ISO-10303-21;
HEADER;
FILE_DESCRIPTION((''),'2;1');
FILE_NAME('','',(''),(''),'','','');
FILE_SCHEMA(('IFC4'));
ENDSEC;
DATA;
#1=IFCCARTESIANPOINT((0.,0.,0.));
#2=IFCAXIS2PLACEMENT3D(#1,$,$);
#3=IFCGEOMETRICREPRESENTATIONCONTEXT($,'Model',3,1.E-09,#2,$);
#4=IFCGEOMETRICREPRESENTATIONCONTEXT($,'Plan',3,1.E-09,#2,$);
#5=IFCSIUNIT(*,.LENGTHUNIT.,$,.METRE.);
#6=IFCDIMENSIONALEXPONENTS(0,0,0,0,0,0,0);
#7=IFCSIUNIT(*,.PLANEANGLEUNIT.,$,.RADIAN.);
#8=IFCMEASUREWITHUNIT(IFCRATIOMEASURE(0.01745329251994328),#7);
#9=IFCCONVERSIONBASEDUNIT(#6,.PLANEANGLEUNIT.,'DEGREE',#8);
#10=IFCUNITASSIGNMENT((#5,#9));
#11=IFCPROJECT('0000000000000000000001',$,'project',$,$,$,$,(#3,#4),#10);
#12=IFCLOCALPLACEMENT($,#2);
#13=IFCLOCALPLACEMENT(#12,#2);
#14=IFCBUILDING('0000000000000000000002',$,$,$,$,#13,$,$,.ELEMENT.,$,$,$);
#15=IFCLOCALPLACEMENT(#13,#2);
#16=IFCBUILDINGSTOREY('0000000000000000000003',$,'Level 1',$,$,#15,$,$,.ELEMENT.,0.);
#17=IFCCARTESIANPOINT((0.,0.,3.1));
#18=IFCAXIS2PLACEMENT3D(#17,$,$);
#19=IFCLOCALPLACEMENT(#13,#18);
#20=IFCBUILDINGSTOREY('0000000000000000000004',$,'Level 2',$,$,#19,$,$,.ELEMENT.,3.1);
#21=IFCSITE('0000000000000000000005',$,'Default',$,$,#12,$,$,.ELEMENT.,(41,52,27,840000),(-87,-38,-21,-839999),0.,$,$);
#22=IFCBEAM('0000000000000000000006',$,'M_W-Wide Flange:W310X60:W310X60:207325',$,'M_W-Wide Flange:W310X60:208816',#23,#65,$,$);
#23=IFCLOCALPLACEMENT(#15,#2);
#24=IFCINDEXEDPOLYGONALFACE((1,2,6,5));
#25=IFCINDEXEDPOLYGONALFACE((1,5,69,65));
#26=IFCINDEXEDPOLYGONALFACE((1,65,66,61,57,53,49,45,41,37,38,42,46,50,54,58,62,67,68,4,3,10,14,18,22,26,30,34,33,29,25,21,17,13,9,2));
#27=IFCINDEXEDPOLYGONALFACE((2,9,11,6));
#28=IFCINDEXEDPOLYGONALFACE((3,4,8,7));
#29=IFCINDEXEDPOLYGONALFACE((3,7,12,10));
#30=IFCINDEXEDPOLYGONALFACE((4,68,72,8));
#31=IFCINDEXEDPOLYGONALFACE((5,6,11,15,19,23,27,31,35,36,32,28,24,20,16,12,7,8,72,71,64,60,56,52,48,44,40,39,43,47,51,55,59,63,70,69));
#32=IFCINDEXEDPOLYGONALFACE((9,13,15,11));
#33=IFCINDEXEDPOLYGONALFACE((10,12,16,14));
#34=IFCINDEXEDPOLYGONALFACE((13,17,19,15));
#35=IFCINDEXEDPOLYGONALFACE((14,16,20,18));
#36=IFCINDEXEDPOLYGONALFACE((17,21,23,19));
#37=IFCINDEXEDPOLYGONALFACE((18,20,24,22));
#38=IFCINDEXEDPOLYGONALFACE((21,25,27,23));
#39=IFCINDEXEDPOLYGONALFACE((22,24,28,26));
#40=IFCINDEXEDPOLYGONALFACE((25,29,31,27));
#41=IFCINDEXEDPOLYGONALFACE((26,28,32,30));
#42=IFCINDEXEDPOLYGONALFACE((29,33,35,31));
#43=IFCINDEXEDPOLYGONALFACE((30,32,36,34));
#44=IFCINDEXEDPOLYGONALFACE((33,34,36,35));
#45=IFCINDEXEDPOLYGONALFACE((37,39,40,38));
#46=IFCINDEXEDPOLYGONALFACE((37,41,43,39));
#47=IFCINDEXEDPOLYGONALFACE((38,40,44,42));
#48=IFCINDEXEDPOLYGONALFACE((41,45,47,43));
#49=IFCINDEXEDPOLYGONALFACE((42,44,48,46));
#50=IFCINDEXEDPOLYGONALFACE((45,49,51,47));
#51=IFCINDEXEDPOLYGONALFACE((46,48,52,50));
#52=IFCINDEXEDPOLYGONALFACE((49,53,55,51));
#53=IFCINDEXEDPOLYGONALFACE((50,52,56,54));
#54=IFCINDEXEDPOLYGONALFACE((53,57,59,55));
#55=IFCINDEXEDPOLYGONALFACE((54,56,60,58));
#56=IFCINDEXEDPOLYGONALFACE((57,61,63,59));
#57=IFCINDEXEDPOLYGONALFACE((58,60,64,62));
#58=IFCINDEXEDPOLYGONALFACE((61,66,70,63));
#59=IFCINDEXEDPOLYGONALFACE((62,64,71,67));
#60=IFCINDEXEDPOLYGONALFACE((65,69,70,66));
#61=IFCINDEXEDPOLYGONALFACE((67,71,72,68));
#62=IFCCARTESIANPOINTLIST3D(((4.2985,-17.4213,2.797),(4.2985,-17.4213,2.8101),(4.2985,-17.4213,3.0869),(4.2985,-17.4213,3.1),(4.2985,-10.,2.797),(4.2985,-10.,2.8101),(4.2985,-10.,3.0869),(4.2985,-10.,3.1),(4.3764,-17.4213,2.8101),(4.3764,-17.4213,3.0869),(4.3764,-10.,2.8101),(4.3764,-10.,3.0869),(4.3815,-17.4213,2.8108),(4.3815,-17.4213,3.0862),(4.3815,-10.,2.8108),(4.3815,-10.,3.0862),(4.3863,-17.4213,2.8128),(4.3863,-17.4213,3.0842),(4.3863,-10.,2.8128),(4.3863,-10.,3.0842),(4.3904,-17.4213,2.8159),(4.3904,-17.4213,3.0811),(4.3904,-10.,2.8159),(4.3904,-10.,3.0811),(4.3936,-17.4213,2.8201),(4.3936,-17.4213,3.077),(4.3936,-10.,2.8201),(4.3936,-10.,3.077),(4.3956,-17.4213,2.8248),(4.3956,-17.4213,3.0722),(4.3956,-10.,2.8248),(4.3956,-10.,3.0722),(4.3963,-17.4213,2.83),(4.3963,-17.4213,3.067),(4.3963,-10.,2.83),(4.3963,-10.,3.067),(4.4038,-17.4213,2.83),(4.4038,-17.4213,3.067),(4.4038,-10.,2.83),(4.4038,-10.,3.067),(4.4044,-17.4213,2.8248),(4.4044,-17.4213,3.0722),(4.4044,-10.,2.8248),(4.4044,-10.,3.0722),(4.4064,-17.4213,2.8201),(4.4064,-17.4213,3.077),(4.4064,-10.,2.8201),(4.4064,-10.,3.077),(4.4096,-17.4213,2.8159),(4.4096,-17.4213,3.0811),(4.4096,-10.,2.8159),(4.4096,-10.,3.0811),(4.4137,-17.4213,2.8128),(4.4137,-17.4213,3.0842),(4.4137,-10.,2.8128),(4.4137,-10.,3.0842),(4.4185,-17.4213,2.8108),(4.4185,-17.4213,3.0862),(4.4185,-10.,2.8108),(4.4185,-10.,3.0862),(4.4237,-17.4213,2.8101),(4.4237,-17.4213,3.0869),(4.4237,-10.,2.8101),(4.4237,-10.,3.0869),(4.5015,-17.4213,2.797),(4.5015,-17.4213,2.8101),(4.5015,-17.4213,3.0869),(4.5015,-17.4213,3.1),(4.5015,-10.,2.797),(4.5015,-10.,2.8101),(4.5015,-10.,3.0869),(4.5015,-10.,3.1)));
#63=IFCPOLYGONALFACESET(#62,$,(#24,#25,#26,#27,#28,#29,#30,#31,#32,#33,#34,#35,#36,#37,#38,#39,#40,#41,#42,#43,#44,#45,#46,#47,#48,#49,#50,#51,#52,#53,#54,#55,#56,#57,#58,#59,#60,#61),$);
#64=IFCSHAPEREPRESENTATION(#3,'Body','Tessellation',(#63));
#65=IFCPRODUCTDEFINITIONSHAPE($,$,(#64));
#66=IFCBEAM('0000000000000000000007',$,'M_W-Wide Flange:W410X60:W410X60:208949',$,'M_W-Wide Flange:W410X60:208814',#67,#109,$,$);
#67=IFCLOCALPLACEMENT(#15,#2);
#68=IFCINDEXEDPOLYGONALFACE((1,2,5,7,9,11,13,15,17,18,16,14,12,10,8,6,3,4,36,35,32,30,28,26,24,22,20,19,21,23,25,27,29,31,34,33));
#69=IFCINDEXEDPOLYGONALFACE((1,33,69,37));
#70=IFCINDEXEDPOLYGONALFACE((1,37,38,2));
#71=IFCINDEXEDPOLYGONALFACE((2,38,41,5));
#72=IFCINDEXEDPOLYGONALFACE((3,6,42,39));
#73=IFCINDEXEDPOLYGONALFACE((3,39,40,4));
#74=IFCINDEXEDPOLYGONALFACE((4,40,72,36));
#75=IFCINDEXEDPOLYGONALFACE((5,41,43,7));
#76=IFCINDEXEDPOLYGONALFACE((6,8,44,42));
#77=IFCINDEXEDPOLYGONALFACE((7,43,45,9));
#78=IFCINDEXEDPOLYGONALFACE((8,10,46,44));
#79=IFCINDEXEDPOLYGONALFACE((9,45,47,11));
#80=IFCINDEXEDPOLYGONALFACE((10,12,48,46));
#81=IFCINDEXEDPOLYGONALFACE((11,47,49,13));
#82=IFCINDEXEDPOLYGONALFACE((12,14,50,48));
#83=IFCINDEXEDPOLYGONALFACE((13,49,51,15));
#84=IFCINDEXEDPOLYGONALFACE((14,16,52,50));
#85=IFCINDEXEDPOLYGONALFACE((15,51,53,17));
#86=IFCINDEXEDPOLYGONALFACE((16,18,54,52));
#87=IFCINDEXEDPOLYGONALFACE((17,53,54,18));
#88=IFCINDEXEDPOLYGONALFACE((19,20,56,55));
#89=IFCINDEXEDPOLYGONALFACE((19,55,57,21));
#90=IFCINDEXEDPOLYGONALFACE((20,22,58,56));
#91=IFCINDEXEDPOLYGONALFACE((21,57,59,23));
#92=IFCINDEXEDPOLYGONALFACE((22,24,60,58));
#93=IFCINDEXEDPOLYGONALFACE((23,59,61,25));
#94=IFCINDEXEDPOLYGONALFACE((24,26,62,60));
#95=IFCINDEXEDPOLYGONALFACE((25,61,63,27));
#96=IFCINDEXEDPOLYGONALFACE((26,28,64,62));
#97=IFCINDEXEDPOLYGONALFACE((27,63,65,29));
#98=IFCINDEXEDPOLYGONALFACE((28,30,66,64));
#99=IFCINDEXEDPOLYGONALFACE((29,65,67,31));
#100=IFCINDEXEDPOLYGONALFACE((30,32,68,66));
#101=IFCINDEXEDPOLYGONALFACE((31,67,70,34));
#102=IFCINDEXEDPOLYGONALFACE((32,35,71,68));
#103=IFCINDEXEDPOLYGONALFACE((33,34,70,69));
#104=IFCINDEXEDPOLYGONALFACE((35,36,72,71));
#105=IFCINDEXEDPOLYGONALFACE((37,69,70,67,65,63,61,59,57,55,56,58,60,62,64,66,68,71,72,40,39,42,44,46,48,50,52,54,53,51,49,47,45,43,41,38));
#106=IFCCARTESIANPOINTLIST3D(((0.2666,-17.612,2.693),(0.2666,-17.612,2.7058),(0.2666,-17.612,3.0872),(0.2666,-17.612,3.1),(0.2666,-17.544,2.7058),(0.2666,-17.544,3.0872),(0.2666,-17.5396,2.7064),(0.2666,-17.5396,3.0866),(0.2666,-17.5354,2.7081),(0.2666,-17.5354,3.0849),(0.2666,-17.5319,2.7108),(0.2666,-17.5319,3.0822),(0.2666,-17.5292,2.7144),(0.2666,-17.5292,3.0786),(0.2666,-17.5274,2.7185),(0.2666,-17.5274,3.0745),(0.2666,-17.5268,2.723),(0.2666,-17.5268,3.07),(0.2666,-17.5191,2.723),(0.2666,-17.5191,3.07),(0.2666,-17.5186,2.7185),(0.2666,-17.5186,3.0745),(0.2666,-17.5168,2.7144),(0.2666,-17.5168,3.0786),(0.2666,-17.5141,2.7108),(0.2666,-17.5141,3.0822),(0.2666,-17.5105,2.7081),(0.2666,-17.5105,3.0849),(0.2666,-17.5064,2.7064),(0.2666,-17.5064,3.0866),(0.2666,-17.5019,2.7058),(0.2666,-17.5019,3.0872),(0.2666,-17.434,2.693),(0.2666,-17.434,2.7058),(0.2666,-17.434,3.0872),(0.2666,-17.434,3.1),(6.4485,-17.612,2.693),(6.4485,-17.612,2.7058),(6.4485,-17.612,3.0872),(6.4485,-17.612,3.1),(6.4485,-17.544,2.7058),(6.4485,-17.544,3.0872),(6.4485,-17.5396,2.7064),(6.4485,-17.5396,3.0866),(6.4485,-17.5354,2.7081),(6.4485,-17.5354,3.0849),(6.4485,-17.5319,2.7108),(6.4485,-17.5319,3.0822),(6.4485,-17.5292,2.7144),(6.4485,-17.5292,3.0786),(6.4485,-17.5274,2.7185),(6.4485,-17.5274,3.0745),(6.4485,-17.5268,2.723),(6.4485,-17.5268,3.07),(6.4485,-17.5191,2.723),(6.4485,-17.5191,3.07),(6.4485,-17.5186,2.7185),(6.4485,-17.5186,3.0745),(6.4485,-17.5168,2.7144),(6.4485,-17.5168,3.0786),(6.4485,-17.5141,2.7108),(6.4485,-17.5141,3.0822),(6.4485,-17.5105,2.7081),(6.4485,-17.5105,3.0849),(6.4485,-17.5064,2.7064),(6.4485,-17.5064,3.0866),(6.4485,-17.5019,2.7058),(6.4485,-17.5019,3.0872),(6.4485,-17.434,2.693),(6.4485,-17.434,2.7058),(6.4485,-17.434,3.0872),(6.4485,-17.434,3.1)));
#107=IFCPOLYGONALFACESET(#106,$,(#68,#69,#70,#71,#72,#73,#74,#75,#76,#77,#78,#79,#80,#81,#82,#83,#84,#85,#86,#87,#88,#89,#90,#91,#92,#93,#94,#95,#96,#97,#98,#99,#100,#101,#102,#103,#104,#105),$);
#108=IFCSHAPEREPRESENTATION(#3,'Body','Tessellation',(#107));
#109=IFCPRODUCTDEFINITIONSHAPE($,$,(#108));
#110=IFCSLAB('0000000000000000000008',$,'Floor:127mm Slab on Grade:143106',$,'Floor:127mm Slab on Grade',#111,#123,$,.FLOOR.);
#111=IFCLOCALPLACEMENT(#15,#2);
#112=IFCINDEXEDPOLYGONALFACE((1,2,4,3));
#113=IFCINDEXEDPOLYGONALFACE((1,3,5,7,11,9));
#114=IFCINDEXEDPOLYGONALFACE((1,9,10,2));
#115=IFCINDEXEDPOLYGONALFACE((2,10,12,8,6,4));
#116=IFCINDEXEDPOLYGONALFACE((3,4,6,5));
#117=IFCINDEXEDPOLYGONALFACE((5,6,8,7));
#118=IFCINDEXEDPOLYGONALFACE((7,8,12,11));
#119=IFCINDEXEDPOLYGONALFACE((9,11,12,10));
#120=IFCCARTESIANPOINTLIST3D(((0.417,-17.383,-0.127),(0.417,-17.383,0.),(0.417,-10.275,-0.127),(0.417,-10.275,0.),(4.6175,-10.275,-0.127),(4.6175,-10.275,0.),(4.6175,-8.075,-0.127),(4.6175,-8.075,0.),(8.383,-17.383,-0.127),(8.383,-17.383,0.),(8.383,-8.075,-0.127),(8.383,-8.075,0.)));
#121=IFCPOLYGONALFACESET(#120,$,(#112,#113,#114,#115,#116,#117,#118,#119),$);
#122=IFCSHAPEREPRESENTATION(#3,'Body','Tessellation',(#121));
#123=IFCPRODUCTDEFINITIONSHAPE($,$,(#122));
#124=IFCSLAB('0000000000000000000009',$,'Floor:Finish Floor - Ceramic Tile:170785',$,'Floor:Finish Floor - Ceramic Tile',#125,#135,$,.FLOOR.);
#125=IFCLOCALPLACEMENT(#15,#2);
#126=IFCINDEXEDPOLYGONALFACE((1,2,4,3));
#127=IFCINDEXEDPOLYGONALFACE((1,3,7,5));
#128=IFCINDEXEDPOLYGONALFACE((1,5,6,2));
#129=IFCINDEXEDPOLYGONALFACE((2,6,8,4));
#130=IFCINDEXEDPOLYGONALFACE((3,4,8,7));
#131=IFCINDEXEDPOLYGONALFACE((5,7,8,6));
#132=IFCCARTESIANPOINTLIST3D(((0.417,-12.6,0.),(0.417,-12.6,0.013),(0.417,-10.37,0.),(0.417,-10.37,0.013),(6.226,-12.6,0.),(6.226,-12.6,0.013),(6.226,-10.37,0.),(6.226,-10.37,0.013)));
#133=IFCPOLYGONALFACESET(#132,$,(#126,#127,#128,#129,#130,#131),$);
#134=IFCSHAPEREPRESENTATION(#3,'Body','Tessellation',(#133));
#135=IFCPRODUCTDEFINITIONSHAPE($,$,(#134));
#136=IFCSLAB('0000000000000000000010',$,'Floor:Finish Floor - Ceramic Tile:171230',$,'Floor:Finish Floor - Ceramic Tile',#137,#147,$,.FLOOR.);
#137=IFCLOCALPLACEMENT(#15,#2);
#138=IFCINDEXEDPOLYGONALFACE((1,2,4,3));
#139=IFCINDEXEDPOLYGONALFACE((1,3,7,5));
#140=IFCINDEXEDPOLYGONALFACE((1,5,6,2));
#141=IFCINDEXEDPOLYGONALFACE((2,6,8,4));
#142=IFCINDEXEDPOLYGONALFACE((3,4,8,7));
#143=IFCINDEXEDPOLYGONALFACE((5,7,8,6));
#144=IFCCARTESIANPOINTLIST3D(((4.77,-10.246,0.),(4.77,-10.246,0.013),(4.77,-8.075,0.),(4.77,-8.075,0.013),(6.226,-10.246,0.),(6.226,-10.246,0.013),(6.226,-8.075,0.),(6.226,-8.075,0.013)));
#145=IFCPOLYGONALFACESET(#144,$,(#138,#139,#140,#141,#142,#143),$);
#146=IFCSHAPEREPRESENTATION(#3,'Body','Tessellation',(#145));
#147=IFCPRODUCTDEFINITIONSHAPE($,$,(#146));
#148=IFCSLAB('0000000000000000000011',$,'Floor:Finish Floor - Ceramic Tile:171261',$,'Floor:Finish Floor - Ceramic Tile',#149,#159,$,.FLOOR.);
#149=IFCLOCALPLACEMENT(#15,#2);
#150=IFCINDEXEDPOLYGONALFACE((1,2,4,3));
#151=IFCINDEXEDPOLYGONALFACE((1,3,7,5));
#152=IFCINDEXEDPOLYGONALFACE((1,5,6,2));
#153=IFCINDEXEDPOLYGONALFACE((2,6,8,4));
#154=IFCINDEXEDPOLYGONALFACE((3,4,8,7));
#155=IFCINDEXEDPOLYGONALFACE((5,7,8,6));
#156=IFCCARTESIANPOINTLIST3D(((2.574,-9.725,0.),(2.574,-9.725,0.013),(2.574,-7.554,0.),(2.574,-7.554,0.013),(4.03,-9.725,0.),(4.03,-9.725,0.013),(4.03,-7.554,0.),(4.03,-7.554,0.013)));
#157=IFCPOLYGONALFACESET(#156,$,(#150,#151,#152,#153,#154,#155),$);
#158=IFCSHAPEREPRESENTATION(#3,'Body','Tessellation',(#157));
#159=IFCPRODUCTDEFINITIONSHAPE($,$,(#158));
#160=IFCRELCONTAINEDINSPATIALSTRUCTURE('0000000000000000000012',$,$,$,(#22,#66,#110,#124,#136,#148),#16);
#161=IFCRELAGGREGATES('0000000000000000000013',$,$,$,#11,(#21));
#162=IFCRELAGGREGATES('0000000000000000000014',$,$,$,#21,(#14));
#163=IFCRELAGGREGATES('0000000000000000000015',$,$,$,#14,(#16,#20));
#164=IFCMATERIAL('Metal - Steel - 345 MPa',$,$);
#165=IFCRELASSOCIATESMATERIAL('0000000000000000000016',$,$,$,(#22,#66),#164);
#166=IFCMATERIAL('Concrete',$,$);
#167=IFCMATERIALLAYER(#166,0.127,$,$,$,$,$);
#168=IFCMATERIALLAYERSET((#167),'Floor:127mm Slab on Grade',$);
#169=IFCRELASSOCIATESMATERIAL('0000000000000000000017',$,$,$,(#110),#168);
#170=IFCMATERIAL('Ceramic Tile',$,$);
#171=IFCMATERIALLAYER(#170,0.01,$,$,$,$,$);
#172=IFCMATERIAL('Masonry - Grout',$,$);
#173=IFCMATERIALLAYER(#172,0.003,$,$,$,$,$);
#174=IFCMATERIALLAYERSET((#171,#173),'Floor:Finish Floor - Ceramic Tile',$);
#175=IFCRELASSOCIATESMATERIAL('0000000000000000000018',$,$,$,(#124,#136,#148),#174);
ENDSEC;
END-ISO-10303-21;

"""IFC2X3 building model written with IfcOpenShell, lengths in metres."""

from ifc_helpers import new_model, entity, si_unit, converted_unit, frame, frame_2d, origin, place, context, project, spatial, polyline, circle_curve, parameter, trimmed, segment, composite_curve, rectangle, outline, extrude, material, layer, layer_set, layer_usage, element, save


model = new_model("IFC2X3")

# Units and contexts
model_context = context("Model", 3, precision=1e-09, world=origin())
plan_context = context("Plan", 3, precision=1e-09, world=origin())
ifc_project = project(units=[si_unit("LENGTHUNIT", "METRE"), converted_unit("PLANEANGLEUNIT", "DEGREE", entity("IfcRatioMeasure", 0.01745329251994328), si_unit("PLANEANGLEUNIT", "RADIAN"), dimensions=[0, 0, 0, 0, 0, 0, 0])], contexts=[model_context, plan_context])

# Site, building, storey
site_placement = place(None, origin())
site = spatial("IfcSite", under=ifc_project, at=site_placement, Name="Default", CompositionType="ELEMENT", RefLatitude=(41, 52, 27, 840000), RefLongitude=(-87, -38, -21, -839999), RefElevation=0.0)
building_placement = place(site_placement, origin())
building = spatial("IfcBuilding", under=site, at=building_placement, CompositionType="ELEMENT")
storey_1_placement = place(building_placement, origin())
storey_1 = spatial("IfcBuildingStorey", under=building, at=storey_1_placement, Name="Level 1", CompositionType="ELEMENT", Elevation=0.0)

# Beams
ifc_material_1 = material(Name="Metal - Steel - 345 MPa")
beam_1_placement = place(storey_1_placement, frame((4.4, -10.0, 3.1), z_axis=(0.0, 0.0, 1.0), x_axis=(-1.0, 0.0, 0.0)))
element("IfcBeam", 1, at=beam_1_placement, inside=storey_1, material=ifc_material_1, Name="M_W-Wide Flange:W310X60:W310X60:207325", ObjectType="M_W-Wide Flange:W310X60:208816", context=model_context, shape_type="SweptSolid", body=[
    extrude(outline(composite_curve([segment(polyline([(0.1384, -0.1015), (0.1515, -0.1015)]), True, "CONTINUOUS"), segment(polyline([(0.1515, -0.1015), (0.1515, 0.1015)]), True, "CONTINUOUS"), segment(polyline([(0.1515, 0.1015), (0.1384, 0.1015)]), True, "CONTINUOUS"), segment(polyline([(0.1384, 0.1015), (0.1384, 0.0236)]), True, "CONTINUOUS"), segment(trimmed(circle_curve(frame_2d((0.1185, 0.0236), x_axis=(0.0, 1.0)), 0.0199), [parameter(180.0)], [parameter(270.0)], True, "PARAMETER"), False, "CONTINUOUS"), segment(polyline([(0.1185, 0.0037), (-0.1185, 0.0037)]), True, "CONTINUOUS"), segment(trimmed(circle_curve(frame_2d((-0.1185, 0.0236), x_axis=(0.0, 1.0)), 0.0199), [parameter(90.0)], [parameter(180.0)], True, "PARAMETER"), False, "CONTINUOUS"), segment(polyline([(-0.1384, 0.0236), (-0.1384, 0.1015)]), True, "CONTINUOUS"), segment(polyline([(-0.1384, 0.1015), (-0.1515, 0.1015)]), True, "CONTINUOUS"), segment(polyline([(-0.1515, 0.1015), (-0.1515, -0.1015)]), True, "CONTINUOUS"), segment(polyline([(-0.1515, -0.1015), (-0.1384, -0.1015)]), True, "CONTINUOUS"), segment(polyline([(-0.1384, -0.1015), (-0.1384, -0.0237)]), True, "CONTINUOUS"), segment(trimmed(circle_curve(frame_2d((-0.1185, -0.0237), x_axis=(0.0, 1.0)), 0.0199), [parameter(360.0)], [parameter(90.0)], True, "PARAMETER"), False, "CONTINUOUS"), segment(polyline([(-0.1185, -0.0038), (0.1185, -0.0038)]), True, "CONTINUOUS"), segment(trimmed(circle_curve(frame_2d((0.1185, -0.0237), x_axis=(0.0, 1.0)), 0.0199), [parameter(270.0)], [parameter(0.0)], True, "PARAMETER"), False, "CONTINUOUS"), segment(polyline([(0.1384, -0.0237), (0.1384, -0.1015)]), True, "CONTINUOUS")], self_intersect=False)), frame((0.0, 7.4213, -0.1515), z_axis=(0.0, -1.0, 0.0), x_axis=(0.0, 0.0, -1.0)), (0.0, 0.0, 1.0), 7.4213),
])
beam_2_placement = place(storey_1_placement, frame((0.2085, -17.523, 3.1), z_axis=(0.0, 0.0, 1.0), x_axis=(0.0, -1.0, 0.0)))
element("IfcBeam", 2, at=beam_2_placement, inside=storey_1, material=ifc_material_1, Name="M_W-Wide Flange:W410X60:W410X60:208949", ObjectType="M_W-Wide Flange:W410X60:208814", context=model_context, shape_type="SweptSolid", body=[
    extrude(outline(composite_curve([segment(polyline([(-0.089, -0.1907), (-0.089, -0.2035)]), True, "CONTINUOUS"), segment(polyline([(-0.089, -0.2035), (0.089, -0.2035)]), True, "CONTINUOUS"), segment(polyline([(0.089, -0.2035), (0.089, -0.1907)]), True, "CONTINUOUS"), segment(polyline([(0.089, -0.1907), (0.021, -0.1907)]), True, "CONTINUOUS"), segment(trimmed(circle_curve(frame_2d((0.021, -0.1735), x_axis=(0.0, -1.0)), 0.0172), [parameter(270.0)], [parameter(360.0)], True, "PARAMETER"), False, "CONTINUOUS"), segment(polyline([(0.0038, -0.1735), (0.0038, 0.1735)]), True, "CONTINUOUS"), segment(trimmed(circle_curve(frame_2d((0.021, 0.1735), x_axis=(-1.0, 0.0)), 0.0172), [parameter(270.0)], [parameter(360.0)], True, "PARAMETER"), False, "CONTINUOUS"), segment(polyline([(0.021, 0.1907), (0.089, 0.1907)]), True, "CONTINUOUS"), segment(polyline([(0.089, 0.1907), (0.089, 0.2035)]), True, "CONTINUOUS"), segment(polyline([(0.089, 0.2035), (-0.089, 0.2035)]), True, "CONTINUOUS"), segment(polyline([(-0.089, 0.2035), (-0.089, 0.1907)]), True, "CONTINUOUS"), segment(polyline([(-0.089, 0.1907), (-0.0211, 0.1907)]), True, "CONTINUOUS"), segment(trimmed(circle_curve(frame_2d((-0.0211, 0.1735), x_axis=(0.0, 1.0)), 0.0172), [parameter(270.0)], [parameter(0.0)], True, "PARAMETER"), False, "CONTINUOUS"), segment(polyline([(-0.0039, 0.1735), (-0.0039, -0.1735)]), True, "CONTINUOUS"), segment(trimmed(circle_curve(frame_2d((-0.0211, -0.1735), x_axis=(1.0, 0.0)), 0.0172), [parameter(270.0)], [parameter(0.0)], True, "PARAMETER"), False, "CONTINUOUS"), segment(polyline([(-0.0211, -0.1907), (-0.089, -0.1907)]), True, "CONTINUOUS")], self_intersect=False)), frame((0.0, 0.0581, -0.2035), z_axis=(0.0, -1.0, 0.0), x_axis=(1.0, 0.0, 0.0)), (0.0, 0.0, -1.0), 6.1819),
])

# Slabs
ifc_material_2 = material(Name="Concrete")
ifc_layer_1 = layer(ifc_material_2, 0.127)
ifc_layer_set_1 = layer_set([ifc_layer_1], Name="Floor:127mm Slab on Grade")
ifc_layer_usage_1 = layer_usage(ifc_layer_set_1, "AXIS3", "POSITIVE", 0.0)
slab_1_placement = place(storey_1_placement, frame((0.417, -17.383, -0.127)))
element("IfcSlab", 3, at=slab_1_placement, inside=storey_1, material=ifc_layer_usage_1, Name="Floor:127mm Slab on Grade:143106", ObjectType="Floor:127mm Slab on Grade", PredefinedType="FLOOR", context=model_context, shape_type="SweptSolid", body=[
    extrude(outline(polyline([(-3.983, 4.654), (-3.983, -4.654), (3.983, -4.654), (3.983, 2.454), (-0.2175, 2.454), (-0.2175, 4.654), (-3.983, 4.654)])), frame((3.983, 4.654, 0.127), z_axis=(0.0, 0.0, -1.0), x_axis=(-1.0, 0.0, 0.0)), (0.0, 0.0, 1.0), 0.127),
])
ifc_material_3 = material(Name="Ceramic Tile")
ifc_layer_2 = layer(ifc_material_3, 0.01)
ifc_material_4 = material(Name="Masonry - Grout")
ifc_layer_3 = layer(ifc_material_4, 0.003)
ifc_layer_set_2 = layer_set([ifc_layer_2, ifc_layer_3], Name="Floor:Finish Floor - Ceramic Tile")
ifc_layer_usage_2 = layer_usage(ifc_layer_set_2, "AXIS3", "POSITIVE", 0.0)
slab_2_placement = place(storey_1_placement, frame((0.417, -12.6, 0.0)))
element("IfcSlab", 4, at=slab_2_placement, inside=storey_1, material=ifc_layer_usage_2, Name="Floor:Finish Floor - Ceramic Tile:170785", ObjectType="Floor:Finish Floor - Ceramic Tile", PredefinedType="FLOOR", context=model_context, shape_type="SweptSolid", body=[
    extrude(rectangle(XDim=5.809, YDim=2.23, at=frame_2d((0.0, 0.0), x_axis=(-1.0, 0.0))), frame((2.9045, 1.115, 0.013), z_axis=(0.0, 0.0, -1.0), x_axis=(-1.0, 0.0, 0.0)), (0.0, 0.0, 1.0), 0.013),
])
ifc_layer_usage_3 = layer_usage(ifc_layer_set_2, "AXIS3", "POSITIVE", 0.0)
slab_3_placement = place(storey_1_placement, frame((4.77, -10.246, 0.0)))
element("IfcSlab", 5, at=slab_3_placement, inside=storey_1, material=ifc_layer_usage_3, Name="Floor:Finish Floor - Ceramic Tile:171230", ObjectType="Floor:Finish Floor - Ceramic Tile", PredefinedType="FLOOR", context=model_context, shape_type="SweptSolid", body=[
    extrude(rectangle(XDim=1.456, YDim=2.171, at=frame_2d((0.0, 0.0), x_axis=(-1.0, 0.0))), frame((0.728, 1.0855, 0.013), z_axis=(0.0, 0.0, -1.0), x_axis=(-1.0, 0.0, 0.0)), (0.0, 0.0, 1.0), 0.013),
])
ifc_layer_usage_4 = layer_usage(ifc_layer_set_2, "AXIS3", "POSITIVE", 0.0)
slab_4_placement = place(storey_1_placement, frame((2.574, -9.725, 0.0)))
element("IfcSlab", 6, at=slab_4_placement, inside=storey_1, material=ifc_layer_usage_4, Name="Floor:Finish Floor - Ceramic Tile:171261", ObjectType="Floor:Finish Floor - Ceramic Tile", PredefinedType="FLOOR", context=model_context, shape_type="SweptSolid", body=[
    extrude(rectangle(XDim=2.171, YDim=1.456, at=frame_2d((0.0, 0.0), x_axis=(0.0, -1.0))), frame((0.728, 1.0855, 0.013), z_axis=(0.0, 0.0, -1.0), x_axis=(-1.0, 0.0, 0.0)), (0.0, 0.0, 1.0), 0.013),
])

# Shared definitions
storey_2_placement = place(building_placement, frame((0.0, 0.0, 3.1)))
storey_2 = spatial("IfcBuildingStorey", under=building, at=storey_2_placement, Name="Level 2", CompositionType="ELEMENT", Elevation=3.1)

save(model, "model.ifc")
